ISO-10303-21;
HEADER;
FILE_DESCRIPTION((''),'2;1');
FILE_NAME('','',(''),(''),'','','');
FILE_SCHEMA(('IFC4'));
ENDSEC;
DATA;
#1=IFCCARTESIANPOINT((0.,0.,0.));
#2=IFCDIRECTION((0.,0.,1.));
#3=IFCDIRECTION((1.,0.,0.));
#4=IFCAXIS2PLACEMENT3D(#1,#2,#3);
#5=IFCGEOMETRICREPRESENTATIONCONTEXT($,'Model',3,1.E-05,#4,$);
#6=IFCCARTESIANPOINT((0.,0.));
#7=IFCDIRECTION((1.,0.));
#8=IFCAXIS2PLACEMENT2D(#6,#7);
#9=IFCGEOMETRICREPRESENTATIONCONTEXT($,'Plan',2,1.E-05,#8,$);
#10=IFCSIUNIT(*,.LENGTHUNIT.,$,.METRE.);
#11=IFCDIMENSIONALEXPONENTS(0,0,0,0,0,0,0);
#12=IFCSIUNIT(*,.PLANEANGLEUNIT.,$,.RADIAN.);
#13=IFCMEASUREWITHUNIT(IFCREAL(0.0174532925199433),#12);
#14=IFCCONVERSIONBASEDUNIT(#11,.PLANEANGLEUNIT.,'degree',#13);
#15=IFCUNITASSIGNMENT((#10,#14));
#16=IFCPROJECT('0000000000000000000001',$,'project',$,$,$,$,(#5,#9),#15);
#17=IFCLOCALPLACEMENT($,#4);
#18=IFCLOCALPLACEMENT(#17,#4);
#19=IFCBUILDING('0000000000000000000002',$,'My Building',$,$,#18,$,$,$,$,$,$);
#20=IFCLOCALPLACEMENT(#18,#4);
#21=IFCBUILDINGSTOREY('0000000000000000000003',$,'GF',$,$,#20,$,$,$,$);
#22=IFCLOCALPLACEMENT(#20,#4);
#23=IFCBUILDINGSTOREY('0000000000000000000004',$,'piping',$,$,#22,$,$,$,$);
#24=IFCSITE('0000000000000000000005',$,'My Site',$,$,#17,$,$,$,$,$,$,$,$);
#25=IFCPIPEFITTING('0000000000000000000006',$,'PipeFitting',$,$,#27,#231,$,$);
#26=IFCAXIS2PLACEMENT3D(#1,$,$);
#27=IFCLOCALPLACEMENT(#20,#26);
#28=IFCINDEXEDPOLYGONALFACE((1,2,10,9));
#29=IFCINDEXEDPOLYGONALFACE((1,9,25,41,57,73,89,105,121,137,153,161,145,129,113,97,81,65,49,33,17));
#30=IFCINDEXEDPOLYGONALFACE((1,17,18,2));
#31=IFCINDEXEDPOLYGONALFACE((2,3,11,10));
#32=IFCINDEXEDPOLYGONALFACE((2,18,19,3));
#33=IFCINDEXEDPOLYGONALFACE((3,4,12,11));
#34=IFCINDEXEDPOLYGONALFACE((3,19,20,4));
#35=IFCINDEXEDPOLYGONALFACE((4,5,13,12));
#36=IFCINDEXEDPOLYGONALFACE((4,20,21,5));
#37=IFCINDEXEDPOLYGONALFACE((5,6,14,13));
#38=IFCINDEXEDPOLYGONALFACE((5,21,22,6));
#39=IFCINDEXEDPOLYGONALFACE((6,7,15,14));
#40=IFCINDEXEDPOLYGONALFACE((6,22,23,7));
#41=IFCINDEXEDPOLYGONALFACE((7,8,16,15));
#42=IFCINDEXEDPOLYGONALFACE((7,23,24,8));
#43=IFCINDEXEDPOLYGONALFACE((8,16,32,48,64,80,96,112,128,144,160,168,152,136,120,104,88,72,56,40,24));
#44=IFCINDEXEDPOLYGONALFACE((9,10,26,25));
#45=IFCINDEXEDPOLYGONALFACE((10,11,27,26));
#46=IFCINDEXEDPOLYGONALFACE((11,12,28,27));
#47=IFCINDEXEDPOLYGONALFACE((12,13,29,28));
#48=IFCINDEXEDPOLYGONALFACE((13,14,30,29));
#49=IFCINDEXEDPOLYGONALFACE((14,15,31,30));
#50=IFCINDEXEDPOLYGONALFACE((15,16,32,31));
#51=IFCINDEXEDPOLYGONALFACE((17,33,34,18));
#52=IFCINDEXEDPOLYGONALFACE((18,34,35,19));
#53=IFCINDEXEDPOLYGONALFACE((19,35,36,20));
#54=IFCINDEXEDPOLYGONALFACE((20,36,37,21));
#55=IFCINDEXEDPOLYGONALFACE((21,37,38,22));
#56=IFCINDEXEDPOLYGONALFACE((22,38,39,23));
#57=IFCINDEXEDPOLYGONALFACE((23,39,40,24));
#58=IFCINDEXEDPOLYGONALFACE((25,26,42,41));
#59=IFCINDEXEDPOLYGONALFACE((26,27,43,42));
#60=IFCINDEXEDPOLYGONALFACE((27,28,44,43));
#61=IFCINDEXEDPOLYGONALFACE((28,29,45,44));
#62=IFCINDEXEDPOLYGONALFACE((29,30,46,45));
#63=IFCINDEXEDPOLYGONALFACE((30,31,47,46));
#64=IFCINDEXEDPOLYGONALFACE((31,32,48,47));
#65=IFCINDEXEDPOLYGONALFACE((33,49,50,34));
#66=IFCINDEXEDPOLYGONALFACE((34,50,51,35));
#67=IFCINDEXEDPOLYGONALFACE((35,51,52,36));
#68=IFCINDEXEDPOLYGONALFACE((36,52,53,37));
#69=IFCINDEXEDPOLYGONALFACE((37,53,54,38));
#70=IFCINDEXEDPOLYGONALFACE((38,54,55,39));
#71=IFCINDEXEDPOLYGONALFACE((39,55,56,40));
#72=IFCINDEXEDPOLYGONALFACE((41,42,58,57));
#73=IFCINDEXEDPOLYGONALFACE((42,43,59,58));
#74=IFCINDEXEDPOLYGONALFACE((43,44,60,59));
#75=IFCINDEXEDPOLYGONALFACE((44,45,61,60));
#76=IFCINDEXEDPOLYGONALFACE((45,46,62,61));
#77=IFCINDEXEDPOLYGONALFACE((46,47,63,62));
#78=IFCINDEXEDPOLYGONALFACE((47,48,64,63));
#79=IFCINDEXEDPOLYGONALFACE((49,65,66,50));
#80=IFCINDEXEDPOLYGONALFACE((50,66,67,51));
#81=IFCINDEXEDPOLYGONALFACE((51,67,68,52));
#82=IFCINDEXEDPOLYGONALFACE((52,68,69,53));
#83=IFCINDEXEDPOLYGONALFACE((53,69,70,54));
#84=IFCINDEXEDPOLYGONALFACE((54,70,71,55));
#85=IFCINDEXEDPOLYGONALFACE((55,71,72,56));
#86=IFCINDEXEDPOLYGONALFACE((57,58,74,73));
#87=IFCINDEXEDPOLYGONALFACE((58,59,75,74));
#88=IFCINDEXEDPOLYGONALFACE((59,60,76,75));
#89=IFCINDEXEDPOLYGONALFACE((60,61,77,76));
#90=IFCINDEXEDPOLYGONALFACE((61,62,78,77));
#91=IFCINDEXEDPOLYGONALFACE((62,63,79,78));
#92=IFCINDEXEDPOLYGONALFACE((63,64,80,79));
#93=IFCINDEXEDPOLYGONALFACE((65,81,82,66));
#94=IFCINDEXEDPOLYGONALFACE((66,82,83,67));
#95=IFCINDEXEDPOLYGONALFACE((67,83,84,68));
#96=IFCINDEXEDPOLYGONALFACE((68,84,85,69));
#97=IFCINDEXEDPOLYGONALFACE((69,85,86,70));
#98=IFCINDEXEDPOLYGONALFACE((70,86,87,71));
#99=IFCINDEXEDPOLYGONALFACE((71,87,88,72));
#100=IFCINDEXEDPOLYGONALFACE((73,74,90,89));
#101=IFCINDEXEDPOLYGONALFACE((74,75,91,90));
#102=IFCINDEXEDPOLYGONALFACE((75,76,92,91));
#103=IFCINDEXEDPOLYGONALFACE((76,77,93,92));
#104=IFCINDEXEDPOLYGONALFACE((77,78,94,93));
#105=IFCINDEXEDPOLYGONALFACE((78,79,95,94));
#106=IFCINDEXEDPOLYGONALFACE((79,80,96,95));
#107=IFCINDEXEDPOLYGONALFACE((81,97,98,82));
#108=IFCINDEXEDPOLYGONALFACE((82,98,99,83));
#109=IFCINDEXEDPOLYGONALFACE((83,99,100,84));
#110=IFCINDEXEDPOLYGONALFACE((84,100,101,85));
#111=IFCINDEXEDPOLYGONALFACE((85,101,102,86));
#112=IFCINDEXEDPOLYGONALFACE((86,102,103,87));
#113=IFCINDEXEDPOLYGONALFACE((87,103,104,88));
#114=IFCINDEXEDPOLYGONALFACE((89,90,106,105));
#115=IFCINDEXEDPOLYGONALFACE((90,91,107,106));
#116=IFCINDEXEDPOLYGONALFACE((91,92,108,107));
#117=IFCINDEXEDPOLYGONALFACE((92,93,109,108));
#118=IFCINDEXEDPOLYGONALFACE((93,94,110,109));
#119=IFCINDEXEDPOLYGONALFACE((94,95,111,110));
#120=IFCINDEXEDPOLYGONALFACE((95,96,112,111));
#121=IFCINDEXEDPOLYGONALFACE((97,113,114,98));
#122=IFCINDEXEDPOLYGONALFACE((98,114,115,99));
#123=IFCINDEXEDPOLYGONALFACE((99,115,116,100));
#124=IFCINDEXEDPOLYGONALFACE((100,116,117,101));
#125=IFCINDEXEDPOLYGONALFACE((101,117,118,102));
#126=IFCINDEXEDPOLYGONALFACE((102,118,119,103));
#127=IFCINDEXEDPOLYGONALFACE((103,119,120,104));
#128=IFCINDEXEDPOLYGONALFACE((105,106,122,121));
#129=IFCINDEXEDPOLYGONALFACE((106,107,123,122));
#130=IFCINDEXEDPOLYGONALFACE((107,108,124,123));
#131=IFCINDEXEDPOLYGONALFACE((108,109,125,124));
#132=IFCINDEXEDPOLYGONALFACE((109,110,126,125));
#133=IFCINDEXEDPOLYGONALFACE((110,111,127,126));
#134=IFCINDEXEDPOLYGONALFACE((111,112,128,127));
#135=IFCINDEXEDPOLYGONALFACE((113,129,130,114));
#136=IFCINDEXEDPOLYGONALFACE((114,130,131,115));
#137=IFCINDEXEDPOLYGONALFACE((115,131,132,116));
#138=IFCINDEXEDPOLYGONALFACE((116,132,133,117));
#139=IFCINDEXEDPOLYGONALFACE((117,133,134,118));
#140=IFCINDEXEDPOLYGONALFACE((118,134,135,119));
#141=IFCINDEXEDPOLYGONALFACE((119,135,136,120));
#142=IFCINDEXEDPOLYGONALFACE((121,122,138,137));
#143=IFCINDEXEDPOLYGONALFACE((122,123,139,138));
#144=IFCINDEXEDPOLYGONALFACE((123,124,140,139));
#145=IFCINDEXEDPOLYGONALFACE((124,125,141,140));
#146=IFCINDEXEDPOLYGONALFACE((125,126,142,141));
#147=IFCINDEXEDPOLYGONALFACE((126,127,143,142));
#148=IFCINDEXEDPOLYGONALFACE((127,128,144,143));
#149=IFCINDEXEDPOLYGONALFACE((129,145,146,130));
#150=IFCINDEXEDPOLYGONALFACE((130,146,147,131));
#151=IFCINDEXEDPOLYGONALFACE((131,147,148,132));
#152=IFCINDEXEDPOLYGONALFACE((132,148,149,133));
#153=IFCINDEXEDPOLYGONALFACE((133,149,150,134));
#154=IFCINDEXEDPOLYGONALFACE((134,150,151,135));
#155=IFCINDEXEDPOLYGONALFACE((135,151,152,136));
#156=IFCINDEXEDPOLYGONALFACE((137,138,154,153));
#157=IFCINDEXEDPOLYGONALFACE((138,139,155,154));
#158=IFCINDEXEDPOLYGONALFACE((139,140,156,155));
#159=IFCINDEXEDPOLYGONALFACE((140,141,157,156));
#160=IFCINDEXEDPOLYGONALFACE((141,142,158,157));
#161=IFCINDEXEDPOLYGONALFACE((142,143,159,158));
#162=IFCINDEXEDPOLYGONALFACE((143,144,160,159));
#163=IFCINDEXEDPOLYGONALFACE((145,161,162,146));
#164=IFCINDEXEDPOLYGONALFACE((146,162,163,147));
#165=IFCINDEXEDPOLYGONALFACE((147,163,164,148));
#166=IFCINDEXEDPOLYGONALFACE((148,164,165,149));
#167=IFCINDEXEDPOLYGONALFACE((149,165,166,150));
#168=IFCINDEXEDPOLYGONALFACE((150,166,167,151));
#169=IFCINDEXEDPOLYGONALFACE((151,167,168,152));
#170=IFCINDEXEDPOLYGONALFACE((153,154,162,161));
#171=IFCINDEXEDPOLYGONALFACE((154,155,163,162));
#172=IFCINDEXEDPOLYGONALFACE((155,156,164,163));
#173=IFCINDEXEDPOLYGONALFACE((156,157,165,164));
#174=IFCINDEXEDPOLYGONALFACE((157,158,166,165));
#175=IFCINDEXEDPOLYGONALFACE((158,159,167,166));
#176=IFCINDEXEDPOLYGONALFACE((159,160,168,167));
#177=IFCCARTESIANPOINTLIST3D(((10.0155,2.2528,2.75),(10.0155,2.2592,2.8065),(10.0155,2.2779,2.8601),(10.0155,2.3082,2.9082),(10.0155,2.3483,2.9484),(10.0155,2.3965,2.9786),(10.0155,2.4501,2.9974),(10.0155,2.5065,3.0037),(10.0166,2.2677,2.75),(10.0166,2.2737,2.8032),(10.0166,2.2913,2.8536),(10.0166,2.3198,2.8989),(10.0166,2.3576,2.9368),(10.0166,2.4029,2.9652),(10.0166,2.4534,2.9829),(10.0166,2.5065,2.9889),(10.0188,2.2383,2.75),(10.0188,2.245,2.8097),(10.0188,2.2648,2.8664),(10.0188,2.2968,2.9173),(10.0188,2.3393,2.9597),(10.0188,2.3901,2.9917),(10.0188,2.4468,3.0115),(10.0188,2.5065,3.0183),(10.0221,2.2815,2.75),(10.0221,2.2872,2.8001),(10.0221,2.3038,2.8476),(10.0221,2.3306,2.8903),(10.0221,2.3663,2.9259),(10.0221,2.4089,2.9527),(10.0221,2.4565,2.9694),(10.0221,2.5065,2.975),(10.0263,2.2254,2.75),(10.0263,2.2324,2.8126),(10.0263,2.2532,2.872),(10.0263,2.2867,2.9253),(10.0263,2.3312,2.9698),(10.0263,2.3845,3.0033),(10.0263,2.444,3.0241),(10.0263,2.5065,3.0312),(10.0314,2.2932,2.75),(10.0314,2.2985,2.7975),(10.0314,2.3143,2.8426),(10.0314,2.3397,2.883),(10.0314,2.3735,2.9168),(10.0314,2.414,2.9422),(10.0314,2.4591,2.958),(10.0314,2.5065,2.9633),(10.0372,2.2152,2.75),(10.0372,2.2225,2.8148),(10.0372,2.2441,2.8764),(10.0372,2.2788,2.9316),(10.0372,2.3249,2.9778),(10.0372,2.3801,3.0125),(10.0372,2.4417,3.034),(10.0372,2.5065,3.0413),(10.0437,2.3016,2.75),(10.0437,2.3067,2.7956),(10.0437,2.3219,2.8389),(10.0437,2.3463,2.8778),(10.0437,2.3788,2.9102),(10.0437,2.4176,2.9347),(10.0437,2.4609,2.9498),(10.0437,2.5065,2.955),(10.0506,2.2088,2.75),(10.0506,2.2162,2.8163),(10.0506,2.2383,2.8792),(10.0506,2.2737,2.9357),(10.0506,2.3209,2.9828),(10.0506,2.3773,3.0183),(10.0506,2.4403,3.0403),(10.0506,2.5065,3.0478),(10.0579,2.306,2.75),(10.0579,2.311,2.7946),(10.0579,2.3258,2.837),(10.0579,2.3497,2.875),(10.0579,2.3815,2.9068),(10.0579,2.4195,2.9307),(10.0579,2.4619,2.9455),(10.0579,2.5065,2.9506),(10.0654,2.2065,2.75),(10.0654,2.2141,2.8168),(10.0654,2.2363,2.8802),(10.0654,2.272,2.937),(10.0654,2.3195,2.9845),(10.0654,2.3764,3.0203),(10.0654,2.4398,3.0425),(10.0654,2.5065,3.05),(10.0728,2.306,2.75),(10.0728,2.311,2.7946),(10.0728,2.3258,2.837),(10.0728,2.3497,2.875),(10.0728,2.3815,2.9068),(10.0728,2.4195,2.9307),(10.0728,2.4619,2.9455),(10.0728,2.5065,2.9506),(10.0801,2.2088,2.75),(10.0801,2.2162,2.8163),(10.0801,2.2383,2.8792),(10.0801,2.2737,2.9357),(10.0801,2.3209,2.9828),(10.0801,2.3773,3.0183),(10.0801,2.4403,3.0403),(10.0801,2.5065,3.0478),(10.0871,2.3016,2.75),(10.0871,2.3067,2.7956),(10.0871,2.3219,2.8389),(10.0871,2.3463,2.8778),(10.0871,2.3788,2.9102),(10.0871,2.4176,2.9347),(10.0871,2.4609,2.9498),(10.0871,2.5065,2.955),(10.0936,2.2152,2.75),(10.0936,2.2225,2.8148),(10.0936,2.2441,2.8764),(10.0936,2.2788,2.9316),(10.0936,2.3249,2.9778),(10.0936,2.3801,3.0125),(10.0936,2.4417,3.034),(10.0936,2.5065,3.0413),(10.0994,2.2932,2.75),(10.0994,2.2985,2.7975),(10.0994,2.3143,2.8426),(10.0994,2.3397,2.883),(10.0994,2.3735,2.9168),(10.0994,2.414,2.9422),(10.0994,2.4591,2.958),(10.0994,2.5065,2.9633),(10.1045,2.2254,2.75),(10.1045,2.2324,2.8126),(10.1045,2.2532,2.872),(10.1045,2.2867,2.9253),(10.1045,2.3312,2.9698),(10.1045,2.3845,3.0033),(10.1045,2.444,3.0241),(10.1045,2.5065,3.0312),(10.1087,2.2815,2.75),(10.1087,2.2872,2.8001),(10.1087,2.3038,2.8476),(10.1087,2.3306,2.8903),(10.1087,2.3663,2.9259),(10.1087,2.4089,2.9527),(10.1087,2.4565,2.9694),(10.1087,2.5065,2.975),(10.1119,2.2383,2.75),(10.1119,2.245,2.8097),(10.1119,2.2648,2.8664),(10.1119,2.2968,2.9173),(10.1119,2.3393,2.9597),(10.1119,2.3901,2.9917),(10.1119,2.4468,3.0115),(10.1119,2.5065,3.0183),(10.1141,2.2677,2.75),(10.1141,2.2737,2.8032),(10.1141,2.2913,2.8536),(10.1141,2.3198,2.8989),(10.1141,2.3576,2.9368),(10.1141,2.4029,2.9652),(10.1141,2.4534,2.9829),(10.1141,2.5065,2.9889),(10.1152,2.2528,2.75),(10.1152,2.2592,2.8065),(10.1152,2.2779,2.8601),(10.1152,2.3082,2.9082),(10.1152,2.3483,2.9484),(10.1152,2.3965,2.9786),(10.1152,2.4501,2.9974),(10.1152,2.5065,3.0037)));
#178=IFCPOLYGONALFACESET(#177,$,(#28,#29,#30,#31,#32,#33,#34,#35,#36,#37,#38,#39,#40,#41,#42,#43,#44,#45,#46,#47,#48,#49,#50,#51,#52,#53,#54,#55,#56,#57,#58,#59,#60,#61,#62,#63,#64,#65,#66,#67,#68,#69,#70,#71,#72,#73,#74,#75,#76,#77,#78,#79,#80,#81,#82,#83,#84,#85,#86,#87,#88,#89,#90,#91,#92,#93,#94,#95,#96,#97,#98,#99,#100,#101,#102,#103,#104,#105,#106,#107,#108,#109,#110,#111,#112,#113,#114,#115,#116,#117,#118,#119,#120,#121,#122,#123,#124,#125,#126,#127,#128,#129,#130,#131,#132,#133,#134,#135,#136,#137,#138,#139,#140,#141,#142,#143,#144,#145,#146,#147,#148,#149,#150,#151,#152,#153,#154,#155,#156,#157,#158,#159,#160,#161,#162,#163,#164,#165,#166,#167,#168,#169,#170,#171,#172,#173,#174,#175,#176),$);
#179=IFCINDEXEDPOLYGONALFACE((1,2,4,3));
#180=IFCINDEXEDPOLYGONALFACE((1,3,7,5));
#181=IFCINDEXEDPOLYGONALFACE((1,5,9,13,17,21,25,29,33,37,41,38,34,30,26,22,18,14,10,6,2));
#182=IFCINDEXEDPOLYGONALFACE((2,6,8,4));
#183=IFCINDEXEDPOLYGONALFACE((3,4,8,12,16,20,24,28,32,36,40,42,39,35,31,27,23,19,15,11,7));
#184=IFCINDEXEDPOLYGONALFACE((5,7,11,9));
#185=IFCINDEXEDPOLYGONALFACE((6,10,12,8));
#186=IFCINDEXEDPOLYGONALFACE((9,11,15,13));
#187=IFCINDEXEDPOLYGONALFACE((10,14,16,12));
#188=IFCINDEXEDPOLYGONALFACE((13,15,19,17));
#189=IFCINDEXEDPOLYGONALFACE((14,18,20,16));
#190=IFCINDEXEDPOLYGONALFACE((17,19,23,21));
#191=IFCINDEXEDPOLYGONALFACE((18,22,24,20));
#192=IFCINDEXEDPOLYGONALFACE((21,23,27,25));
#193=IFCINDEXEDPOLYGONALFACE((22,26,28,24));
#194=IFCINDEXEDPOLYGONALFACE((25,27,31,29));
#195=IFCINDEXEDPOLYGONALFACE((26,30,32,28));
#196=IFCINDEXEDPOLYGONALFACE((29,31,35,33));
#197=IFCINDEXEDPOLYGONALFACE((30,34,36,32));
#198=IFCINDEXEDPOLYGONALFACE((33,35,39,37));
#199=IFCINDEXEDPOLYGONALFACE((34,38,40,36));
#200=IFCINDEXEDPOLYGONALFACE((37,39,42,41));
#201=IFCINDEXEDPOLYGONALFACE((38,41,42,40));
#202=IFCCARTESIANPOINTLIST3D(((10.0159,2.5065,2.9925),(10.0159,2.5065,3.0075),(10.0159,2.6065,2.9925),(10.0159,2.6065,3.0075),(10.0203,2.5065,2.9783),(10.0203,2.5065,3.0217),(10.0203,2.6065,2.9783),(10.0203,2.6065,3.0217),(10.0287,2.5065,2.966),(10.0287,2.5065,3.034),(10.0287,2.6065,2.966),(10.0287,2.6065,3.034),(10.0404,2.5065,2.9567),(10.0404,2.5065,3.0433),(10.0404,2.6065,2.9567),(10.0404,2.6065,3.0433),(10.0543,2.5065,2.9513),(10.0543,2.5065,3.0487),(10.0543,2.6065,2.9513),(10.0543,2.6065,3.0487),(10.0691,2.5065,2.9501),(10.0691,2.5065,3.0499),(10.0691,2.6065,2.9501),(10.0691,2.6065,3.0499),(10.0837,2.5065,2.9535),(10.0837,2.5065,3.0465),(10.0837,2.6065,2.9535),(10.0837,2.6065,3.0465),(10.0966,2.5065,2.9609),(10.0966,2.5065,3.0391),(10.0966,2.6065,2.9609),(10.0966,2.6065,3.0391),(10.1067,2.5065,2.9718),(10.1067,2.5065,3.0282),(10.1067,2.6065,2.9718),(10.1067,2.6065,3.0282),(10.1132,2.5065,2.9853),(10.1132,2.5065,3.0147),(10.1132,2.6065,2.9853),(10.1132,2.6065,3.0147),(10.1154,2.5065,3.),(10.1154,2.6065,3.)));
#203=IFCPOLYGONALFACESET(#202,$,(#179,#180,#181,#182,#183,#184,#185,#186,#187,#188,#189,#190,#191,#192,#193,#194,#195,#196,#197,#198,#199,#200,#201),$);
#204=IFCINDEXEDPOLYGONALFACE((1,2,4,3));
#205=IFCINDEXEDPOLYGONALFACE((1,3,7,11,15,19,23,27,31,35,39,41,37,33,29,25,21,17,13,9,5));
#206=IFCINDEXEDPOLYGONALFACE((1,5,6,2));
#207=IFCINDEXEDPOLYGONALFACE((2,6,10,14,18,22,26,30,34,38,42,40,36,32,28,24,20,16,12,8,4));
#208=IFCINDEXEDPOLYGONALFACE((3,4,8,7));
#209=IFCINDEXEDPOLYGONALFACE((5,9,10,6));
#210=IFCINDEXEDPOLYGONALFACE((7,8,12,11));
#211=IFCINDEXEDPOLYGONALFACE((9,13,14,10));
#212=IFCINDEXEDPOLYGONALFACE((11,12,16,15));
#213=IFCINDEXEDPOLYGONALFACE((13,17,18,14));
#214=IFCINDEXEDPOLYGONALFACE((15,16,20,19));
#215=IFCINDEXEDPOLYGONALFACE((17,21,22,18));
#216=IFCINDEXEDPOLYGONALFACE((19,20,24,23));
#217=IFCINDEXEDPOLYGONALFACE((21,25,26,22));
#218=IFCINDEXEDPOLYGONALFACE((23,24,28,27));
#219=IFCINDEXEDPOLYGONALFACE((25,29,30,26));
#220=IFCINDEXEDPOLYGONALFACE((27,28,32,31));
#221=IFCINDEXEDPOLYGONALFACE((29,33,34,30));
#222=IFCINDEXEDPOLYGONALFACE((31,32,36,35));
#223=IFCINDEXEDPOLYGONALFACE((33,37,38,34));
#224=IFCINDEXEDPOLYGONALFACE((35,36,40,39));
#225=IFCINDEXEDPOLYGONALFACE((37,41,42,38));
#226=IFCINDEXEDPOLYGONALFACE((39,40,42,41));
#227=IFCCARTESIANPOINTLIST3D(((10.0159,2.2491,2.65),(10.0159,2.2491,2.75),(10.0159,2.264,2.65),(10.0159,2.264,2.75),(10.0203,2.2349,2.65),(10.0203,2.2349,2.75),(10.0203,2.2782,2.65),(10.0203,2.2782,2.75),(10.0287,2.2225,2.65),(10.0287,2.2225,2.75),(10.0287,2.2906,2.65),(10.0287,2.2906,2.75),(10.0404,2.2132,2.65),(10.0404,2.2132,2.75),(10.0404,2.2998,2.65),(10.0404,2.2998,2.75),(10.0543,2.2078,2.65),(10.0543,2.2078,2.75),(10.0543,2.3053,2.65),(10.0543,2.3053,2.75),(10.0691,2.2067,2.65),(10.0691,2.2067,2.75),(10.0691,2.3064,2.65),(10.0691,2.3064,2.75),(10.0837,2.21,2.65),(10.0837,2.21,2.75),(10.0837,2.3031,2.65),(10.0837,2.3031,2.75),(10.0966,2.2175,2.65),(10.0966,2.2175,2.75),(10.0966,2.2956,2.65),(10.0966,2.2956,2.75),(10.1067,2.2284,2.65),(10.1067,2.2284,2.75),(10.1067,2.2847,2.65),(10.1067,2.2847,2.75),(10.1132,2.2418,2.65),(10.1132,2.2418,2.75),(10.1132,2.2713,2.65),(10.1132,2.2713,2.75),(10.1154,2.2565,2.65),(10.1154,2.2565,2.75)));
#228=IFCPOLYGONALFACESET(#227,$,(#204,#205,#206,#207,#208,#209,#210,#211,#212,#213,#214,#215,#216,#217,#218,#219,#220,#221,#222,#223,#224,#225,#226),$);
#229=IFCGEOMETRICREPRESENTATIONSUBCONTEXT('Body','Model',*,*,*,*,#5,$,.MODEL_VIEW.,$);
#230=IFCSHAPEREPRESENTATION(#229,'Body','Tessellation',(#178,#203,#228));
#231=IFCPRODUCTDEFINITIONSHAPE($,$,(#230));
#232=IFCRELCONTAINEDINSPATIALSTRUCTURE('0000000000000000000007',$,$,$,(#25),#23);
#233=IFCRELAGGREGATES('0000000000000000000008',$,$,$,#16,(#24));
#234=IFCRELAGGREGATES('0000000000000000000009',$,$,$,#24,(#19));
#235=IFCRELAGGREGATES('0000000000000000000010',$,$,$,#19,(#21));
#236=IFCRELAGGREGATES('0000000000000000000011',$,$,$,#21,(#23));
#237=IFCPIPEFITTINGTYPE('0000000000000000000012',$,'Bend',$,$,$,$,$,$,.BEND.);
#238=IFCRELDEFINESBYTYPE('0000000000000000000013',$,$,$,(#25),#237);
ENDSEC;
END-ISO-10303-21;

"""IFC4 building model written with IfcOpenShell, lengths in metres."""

from ifc_helpers import new_model, entity, si_unit, converted_unit, frame, origin_with_axes, origin_2d_with_axis, place, context, subcontext, project, spatial, circle, extrude, source, transform, mapped, type_object, type_shapes, element, save


model = new_model("IFC4")

# Units and contexts
model_context = context("Model", 3, precision=1e-05, world=origin_with_axes())
plan_context = context("Plan", 2, precision=1e-05, world=origin_2d_with_axis())
body_context = subcontext(model_context, "Body", "Model", "MODEL_VIEW")
ifc_project = project(units=[si_unit("LENGTHUNIT", "METRE"), converted_unit("PLANEANGLEUNIT", "degree", entity("IfcReal", 0.0174532925199433), si_unit("PLANEANGLEUNIT", "RADIAN"), dimensions=[0, 0, 0, 0, 0, 0, 0])], contexts=[model_context, plan_context])

# Site, building, storeys
site_placement = place(None, origin_with_axes())
site = spatial("IfcSite", under=ifc_project, at=site_placement, Name="My Site")
building_placement = place(site_placement, origin_with_axes())
building = spatial("IfcBuilding", under=site, at=building_placement, Name="My Building")
storey_1_placement = place(building_placement, origin_with_axes())
storey_1 = spatial("IfcBuildingStorey", under=building, at=storey_1_placement, Name="GF")
storey_2_placement = place(storey_1_placement, origin_with_axes())
storey_2 = spatial("IfcBuildingStorey", under=storey_1, at=storey_2_placement, Name="piping")

# Pipe fitting
pipe_fitting_type = type_object("IfcPipeFittingType", Name="Bend", PredefinedType="BEND")
shared_shape = source(origin_with_axes(), body_context, "Body", "SolidModel", [
    entity("IfcSweptDiskSolid", entity("IfcIndexedPolyCurve", entity("IfcCartesianPointList3D", [[0.0, 0.0, 0.1], [0.0, -0.0732, 0.2768], [0.0, -0.25, 0.35]]), [entity("IfcArcIndex", [1, 2, 3])]), 0.05),
    extrude(circle(Radius=0.05), origin_with_axes(), (0.0, 0.0, 1.0), 0.1),
    extrude(circle(Radius=0.05), frame((0.0, -0.25, 0.35), z_axis=(0.0, -1.0, 0.0), x_axis=(1.0, 0.0, 0.0)), (0.0, 0.0, 1.0), 0.1),
])
type_shapes(pipe_fitting_type, [shared_shape])
for number, where, z_axis, x_axis, name in (
    (1, (10.0654, 2.6065, 3.0), (0.0, -1.0, 0.0), (1.0, 0.0, 0.0), "PipeFitting"),
):
    element("IfcPipeFitting", number, at=place(storey_2_placement, frame(where, z_axis=z_axis, x_axis=x_axis)), inside=storey_2, type_object=pipe_fitting_type, Name=name, context=body_context, shape_type="MappedRepresentation", body=[
        mapped(shared_shape, transform((0.0, 0.0, 0.0), x_axis=(1.0, 0.0, 0.0), y_axis=(0.0, 1.0, 0.0), z_axis=(0.0, 0.0, 1.0), scale=1.0)),
    ])

save(model, "model.ifc")
